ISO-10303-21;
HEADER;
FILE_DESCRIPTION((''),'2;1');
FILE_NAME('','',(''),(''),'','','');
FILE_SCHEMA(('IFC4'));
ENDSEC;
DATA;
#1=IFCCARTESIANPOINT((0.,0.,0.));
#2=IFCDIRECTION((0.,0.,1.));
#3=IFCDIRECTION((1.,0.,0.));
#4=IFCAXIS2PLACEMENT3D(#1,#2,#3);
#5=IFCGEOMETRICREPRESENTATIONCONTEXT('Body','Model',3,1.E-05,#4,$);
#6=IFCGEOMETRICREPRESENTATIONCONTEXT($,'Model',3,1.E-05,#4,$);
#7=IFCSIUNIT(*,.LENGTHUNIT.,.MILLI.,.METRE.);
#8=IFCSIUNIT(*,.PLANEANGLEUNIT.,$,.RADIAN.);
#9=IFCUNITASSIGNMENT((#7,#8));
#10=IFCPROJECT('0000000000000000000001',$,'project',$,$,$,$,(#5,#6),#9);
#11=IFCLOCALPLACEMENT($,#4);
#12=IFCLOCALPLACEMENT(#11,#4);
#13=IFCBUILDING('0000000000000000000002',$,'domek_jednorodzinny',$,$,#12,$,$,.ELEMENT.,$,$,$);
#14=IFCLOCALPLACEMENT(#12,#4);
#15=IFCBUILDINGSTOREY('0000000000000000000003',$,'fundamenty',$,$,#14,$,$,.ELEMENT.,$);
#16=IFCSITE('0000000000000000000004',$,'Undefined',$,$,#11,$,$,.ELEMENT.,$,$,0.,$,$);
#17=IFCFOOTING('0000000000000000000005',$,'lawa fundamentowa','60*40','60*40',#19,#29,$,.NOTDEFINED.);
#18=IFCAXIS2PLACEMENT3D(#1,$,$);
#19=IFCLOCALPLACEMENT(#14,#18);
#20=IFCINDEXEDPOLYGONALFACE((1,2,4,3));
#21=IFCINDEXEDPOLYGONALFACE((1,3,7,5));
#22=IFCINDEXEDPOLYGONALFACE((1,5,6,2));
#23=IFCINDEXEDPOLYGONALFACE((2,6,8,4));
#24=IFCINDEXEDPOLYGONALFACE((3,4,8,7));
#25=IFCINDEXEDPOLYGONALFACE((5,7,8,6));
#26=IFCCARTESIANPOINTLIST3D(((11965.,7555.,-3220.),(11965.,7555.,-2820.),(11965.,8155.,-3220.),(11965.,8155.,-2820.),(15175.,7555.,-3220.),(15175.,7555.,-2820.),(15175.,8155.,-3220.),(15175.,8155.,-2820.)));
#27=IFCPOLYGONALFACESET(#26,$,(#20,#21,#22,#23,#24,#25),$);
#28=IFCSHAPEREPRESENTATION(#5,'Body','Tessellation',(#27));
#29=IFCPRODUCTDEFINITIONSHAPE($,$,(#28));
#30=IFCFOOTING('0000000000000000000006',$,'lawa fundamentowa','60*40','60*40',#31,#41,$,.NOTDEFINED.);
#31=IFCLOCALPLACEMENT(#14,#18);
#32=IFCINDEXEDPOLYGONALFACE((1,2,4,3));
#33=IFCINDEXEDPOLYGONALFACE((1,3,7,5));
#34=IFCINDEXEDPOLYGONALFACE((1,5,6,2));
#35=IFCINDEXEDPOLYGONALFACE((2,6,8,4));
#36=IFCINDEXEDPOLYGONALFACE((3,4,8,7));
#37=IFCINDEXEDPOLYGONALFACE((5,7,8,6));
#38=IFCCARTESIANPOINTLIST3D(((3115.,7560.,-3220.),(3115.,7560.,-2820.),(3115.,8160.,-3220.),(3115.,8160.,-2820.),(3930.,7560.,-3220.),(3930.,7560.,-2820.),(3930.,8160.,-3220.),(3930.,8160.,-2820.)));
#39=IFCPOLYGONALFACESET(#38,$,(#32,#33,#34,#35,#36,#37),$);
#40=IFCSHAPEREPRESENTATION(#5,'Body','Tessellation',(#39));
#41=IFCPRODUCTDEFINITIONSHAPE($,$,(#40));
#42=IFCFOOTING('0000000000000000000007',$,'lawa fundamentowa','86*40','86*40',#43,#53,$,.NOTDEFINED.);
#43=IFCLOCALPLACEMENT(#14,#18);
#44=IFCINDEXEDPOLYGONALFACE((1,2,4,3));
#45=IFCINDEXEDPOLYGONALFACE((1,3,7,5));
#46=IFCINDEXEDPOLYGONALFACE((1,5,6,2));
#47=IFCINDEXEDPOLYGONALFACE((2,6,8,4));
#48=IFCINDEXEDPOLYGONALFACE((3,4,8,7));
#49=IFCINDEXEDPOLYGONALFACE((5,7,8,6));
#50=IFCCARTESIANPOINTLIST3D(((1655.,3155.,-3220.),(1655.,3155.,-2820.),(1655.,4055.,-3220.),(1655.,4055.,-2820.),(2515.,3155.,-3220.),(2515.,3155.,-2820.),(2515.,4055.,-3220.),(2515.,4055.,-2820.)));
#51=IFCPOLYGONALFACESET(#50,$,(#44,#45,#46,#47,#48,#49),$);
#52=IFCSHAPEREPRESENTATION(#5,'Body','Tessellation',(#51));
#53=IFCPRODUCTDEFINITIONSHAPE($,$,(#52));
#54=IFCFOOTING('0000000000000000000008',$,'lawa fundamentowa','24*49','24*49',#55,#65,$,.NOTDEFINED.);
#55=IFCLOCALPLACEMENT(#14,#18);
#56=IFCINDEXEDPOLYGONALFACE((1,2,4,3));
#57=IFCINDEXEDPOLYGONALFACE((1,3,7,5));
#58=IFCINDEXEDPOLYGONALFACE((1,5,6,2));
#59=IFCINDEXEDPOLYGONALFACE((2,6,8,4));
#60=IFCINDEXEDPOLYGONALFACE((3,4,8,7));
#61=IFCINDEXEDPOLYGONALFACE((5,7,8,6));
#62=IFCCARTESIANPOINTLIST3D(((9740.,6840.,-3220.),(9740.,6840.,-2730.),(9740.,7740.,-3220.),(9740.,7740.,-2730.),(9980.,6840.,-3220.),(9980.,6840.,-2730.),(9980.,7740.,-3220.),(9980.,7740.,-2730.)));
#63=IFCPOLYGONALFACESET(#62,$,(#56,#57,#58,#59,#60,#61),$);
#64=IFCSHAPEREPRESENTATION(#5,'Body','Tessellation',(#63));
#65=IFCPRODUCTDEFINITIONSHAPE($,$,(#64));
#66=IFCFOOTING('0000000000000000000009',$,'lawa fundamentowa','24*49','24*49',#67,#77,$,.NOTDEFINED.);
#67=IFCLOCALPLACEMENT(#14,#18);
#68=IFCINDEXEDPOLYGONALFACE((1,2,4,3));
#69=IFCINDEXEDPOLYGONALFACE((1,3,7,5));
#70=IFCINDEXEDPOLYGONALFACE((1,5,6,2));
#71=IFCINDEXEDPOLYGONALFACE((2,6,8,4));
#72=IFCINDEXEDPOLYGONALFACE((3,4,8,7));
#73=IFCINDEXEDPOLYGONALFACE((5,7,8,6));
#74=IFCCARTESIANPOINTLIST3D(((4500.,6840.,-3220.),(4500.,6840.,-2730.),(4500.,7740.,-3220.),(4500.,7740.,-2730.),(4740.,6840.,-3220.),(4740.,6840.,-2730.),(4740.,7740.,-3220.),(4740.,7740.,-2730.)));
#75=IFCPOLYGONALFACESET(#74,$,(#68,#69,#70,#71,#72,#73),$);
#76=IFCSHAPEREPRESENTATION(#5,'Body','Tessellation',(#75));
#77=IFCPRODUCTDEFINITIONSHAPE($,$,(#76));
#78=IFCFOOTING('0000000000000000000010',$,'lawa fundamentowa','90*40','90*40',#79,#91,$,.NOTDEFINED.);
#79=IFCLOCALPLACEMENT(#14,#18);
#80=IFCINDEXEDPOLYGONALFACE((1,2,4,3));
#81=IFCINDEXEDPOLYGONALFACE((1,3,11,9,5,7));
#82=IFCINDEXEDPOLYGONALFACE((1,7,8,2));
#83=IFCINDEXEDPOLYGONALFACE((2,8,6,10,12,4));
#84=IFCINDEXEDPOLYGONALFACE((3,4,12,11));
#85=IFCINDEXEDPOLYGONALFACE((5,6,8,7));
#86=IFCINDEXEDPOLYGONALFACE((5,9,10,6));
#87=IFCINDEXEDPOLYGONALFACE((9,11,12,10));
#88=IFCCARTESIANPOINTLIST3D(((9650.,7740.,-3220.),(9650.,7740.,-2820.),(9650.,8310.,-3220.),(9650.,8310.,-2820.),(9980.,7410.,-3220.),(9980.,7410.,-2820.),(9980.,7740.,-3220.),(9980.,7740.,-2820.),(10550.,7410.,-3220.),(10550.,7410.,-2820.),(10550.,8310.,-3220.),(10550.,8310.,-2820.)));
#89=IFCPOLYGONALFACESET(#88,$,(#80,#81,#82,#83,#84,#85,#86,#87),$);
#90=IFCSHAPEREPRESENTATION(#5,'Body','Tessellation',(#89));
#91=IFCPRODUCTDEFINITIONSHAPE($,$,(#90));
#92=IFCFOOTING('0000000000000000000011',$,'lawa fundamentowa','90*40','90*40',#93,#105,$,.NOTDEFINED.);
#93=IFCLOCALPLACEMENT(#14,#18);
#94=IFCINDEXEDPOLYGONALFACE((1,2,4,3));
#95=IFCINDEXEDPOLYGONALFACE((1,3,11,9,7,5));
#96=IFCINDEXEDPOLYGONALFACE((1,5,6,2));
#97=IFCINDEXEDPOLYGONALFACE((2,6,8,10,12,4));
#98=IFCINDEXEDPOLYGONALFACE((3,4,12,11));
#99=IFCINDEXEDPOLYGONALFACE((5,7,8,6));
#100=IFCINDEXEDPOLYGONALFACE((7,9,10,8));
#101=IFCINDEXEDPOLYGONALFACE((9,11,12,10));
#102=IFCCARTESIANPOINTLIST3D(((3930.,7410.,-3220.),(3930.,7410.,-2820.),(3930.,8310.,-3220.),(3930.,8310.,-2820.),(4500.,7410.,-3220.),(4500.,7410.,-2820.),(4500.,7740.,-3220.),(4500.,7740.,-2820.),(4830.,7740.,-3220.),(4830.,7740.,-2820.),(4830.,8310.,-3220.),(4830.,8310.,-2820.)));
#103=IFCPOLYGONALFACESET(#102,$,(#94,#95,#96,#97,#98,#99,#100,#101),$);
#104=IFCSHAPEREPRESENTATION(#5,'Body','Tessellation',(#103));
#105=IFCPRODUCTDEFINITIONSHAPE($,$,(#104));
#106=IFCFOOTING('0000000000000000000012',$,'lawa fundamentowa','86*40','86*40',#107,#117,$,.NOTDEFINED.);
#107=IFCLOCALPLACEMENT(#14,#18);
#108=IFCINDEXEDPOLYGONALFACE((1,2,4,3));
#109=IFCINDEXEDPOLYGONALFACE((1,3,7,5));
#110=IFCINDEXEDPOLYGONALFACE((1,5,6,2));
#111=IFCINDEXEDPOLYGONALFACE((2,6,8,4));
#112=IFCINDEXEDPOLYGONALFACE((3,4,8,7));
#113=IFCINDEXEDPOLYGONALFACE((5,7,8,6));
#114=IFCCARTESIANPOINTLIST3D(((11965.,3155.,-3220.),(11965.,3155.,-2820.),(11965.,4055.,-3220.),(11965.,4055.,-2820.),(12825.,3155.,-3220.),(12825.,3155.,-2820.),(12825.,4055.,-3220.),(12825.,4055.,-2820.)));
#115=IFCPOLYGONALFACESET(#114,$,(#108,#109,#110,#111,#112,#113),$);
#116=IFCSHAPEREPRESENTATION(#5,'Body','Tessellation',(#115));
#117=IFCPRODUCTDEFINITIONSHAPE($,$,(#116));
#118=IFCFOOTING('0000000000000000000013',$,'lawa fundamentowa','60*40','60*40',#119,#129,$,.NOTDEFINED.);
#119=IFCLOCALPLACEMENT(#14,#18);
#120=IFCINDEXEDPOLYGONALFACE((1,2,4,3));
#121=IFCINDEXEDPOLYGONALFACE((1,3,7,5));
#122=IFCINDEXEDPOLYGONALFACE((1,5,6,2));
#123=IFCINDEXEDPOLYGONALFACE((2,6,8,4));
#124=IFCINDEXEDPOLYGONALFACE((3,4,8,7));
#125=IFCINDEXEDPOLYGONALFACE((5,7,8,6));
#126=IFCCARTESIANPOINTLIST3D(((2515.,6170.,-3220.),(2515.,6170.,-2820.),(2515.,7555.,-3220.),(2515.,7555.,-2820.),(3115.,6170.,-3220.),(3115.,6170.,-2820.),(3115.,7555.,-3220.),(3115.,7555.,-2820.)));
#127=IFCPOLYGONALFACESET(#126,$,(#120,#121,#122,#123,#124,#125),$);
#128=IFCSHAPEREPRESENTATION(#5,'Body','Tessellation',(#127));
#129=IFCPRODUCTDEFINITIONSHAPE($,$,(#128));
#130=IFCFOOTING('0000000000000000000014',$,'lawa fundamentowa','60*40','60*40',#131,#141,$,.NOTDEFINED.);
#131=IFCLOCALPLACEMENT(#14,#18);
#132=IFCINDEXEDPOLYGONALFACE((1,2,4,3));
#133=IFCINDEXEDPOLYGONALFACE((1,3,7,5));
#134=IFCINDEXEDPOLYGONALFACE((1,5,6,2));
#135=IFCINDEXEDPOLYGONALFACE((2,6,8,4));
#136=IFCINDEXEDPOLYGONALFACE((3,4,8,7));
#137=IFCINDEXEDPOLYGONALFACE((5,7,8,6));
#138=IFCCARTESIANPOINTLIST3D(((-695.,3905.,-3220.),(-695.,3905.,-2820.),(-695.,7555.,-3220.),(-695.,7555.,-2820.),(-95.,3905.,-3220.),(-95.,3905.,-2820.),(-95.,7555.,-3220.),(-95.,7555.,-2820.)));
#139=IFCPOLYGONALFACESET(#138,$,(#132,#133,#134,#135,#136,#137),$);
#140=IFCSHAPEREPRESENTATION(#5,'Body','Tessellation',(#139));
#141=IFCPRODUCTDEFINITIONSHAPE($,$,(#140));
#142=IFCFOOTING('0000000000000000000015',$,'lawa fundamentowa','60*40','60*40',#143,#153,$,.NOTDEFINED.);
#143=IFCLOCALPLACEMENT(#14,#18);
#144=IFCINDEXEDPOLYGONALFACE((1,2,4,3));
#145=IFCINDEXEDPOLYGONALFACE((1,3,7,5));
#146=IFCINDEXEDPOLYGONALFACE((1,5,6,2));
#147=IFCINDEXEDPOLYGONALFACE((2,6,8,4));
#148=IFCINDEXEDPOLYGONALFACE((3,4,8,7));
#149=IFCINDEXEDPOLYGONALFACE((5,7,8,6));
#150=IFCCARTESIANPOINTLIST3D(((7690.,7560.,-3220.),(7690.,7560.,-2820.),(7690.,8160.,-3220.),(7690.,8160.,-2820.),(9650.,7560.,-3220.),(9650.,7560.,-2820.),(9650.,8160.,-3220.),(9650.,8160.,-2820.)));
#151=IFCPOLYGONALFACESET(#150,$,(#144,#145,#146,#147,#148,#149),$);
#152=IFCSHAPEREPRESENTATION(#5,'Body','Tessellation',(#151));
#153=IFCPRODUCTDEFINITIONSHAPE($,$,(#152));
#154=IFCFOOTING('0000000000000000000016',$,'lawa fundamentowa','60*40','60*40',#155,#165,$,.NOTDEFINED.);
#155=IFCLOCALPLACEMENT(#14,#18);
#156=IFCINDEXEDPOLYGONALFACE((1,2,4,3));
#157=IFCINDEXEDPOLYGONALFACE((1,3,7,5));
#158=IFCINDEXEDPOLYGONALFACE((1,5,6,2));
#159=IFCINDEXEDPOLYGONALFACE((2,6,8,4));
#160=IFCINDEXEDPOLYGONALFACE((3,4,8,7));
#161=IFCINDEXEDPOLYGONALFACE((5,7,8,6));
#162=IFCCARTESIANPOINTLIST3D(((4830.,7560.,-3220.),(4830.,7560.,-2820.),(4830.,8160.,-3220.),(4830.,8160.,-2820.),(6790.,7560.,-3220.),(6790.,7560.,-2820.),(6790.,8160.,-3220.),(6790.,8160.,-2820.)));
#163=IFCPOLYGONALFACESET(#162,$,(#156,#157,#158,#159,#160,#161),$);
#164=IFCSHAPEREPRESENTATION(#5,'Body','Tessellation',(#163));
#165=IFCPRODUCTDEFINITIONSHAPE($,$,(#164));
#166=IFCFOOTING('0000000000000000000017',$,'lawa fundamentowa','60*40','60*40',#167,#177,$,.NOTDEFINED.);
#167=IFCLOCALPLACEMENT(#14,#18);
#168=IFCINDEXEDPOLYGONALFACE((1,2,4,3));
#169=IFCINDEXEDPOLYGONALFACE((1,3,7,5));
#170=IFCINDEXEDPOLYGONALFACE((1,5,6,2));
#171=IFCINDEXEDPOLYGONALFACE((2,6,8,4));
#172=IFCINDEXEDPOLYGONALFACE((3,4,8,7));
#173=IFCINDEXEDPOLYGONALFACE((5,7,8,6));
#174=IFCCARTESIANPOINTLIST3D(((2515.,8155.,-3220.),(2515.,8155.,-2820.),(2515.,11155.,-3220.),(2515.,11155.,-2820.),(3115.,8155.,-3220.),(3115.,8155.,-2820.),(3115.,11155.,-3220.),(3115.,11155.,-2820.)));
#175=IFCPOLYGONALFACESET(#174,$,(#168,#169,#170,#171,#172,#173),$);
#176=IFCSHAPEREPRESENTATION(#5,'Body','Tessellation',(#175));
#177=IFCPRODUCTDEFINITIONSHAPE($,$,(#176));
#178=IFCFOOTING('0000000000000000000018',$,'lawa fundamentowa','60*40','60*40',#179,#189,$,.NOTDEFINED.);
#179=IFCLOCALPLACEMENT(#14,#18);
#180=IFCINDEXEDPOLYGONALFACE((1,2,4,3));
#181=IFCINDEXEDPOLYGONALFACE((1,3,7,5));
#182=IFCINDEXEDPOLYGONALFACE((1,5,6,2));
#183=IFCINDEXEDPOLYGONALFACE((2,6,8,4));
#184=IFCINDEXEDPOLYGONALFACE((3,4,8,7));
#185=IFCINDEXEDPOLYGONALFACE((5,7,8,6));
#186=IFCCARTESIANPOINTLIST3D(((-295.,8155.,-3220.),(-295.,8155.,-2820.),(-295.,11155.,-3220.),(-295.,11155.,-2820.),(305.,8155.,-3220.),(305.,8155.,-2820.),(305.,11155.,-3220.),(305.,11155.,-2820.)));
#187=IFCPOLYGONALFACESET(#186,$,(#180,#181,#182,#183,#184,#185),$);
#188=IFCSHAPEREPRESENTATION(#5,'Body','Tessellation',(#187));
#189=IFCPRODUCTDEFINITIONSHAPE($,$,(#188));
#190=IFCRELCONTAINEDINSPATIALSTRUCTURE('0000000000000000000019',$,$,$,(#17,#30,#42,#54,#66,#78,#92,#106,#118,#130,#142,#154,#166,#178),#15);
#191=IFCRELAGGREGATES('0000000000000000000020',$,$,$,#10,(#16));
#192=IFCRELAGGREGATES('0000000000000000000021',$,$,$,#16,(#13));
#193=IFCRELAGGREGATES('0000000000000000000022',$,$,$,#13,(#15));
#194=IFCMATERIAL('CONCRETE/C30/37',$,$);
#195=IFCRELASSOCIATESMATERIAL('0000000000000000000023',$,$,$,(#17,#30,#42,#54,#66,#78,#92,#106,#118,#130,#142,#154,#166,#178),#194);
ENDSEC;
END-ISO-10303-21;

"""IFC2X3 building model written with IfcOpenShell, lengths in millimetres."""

from ifc_helpers import new_model, si_unit, frame, origin_with_axes, origin_2d_with_axis, place, context, project, spatial, polyline, rectangle, outline, extrude, material, element, save


model = new_model("IFC2X3")

# Units and contexts
model_context_1 = context("Model", 3, precision=1e-05, world=origin_with_axes(), identifier="Body")
model_context_2 = context("Model", 3, precision=1e-05, world=origin_with_axes())
ifc_project = project(units=[si_unit("LENGTHUNIT", "METRE", prefix="MILLI"), si_unit("PLANEANGLEUNIT", "RADIAN")], contexts=[model_context_1, model_context_2])

# Site, building, storey
site_placement = place(None, origin_with_axes())
site = spatial("IfcSite", under=ifc_project, at=site_placement, Name="Undefined", CompositionType="ELEMENT", RefElevation=0.0)
building_placement = place(site_placement, origin_with_axes())
building = spatial("IfcBuilding", under=site, at=building_placement, Name="domek_jednorodzinny", CompositionType="ELEMENT")
storey_placement = place(building_placement, origin_with_axes())
storey = spatial("IfcBuildingStorey", under=building, at=storey_placement, Name="fundamenty", CompositionType="ELEMENT")

# Footings
ifc_material = material(Name="CONCRETE/C30/37")
footing_1_placement = place(storey_placement, frame((11965.0, 7855.0, -3020.0), z_axis=(0.0, 0.0, 1.0), x_axis=(1.0, 0.0, 0.0)))
element("IfcFooting", 1, at=footing_1_placement, inside=storey, material=ifc_material, Name="lawa fundamentowa", Description="60*40", ObjectType="60*40", PredefinedType="NOTDEFINED", context=model_context_1, shape_type="SweptSolid", body=[
    extrude(rectangle(XDim=600.0, YDim=400.0, at=origin_2d_with_axis()), frame((3210.0, 0.0, 0.0), z_axis=(-1.0, 0.0, 0.0), x_axis=(0.0, -1.0, 0.0)), (0.0, 0.0, 1.0), 3210.0),
])
footing_2_placement = place(storey_placement, frame((3115.0, 7860.0, -3020.0), z_axis=(0.0, 0.0, 1.0), x_axis=(1.0, 0.0, 0.0)))
element("IfcFooting", 2, at=footing_2_placement, inside=storey, material=ifc_material, Name="lawa fundamentowa", Description="60*40", ObjectType="60*40", PredefinedType="NOTDEFINED", context=model_context_1, shape_type="SweptSolid", body=[
    extrude(rectangle(XDim=600.0, YDim=400.0, at=origin_2d_with_axis()), frame((815.0, 0.0, 0.0), z_axis=(-1.0, 0.0, 0.0), x_axis=(0.0, -1.0, 0.0)), (0.0, 0.0, 1.0), 815.0),
])
footing_3_placement = place(storey_placement, frame((2085.0, 3155.0, -3020.0), z_axis=(0.0, 0.0, 1.0), x_axis=(0.0, 1.0, 0.0)))
element("IfcFooting", 3, at=footing_3_placement, inside=storey, material=ifc_material, Name="lawa fundamentowa", Description="86*40", ObjectType="86*40", PredefinedType="NOTDEFINED", context=model_context_1, shape_type="SweptSolid", body=[
    extrude(rectangle(XDim=860.0, YDim=400.0, at=origin_2d_with_axis()), frame((900.0, 0.0, 0.0), z_axis=(-1.0, 0.0, 0.0), x_axis=(0.0, -1.0, 0.0)), (0.0, 0.0, 1.0), 900.0),
])
footing_4_placement = place(storey_placement, frame((9860.0, 6840.0, -2975.0), z_axis=(0.0, 0.0, 1.0), x_axis=(0.0, 1.0, 0.0)))
element("IfcFooting", 4, at=footing_4_placement, inside=storey, material=ifc_material, Name="lawa fundamentowa", Description="24*49", ObjectType="24*49", PredefinedType="NOTDEFINED", context=model_context_1, shape_type="SweptSolid", body=[
    extrude(rectangle(XDim=240.0, YDim=490.0, at=origin_2d_with_axis()), frame((900.0, 0.0, 0.0), z_axis=(-1.0, 0.0, 0.0), x_axis=(0.0, -1.0, 0.0)), (0.0, 0.0, 1.0), 900.0),
])
footing_5_placement = place(storey_placement, frame((4620.0, 6840.0, -2975.0), z_axis=(0.0, 0.0, 1.0), x_axis=(0.0, 1.0, 0.0)))
element("IfcFooting", 5, at=footing_5_placement, inside=storey, material=ifc_material, Name="lawa fundamentowa", Description="24*49", ObjectType="24*49", PredefinedType="NOTDEFINED", context=model_context_1, shape_type="SweptSolid", body=[
    extrude(rectangle(XDim=240.0, YDim=490.0, at=origin_2d_with_axis()), frame((900.0, 0.0, 0.0), z_axis=(-1.0, 0.0, 0.0), x_axis=(0.0, -1.0, 0.0)), (0.0, 0.0, 1.0), 900.0),
])

# Footings, openings
footing_6_placement = place(storey_placement, frame((10100.0, 8310.0, -3020.0), z_axis=(0.0, 0.0, 1.0), x_axis=(0.0, -1.0, 0.0)))
footing_6 = element("IfcFooting", 6, at=footing_6_placement, inside=storey, material=ifc_material, Name="lawa fundamentowa", Description="90*40", ObjectType="90*40", PredefinedType="NOTDEFINED", context=model_context_1, shape_type="SweptSolid", body=[
    extrude(rectangle(XDim=900.0, YDim=400.0, at=origin_2d_with_axis()), frame((900.0, 0.0, 0.0), z_axis=(-1.0, 0.0, 0.0), x_axis=(0.0, -1.0, 0.0)), (0.0, 0.0, 1.0), 900.0),
])
opening_1_placement = place(storey_placement, frame((10100.0, 8310.0, -3020.0), z_axis=(0.0, 0.0, 1.0), x_axis=(0.0, -1.0, 0.0)))
element("IfcOpeningElement", 7, at=opening_1_placement, cuts=footing_6, ObjectType="Recess", context=model_context_1, shape_type="SweptSolid", body=[
    extrude(outline(polyline([(0.0, 0.0), (330.0, 0.0), (330.0, 330.0), (0.0, 330.0), (0.0, 0.0)])), frame((570.0, -450.0, 202.5), z_axis=(0.000001, 0.000001, -1.0), x_axis=(0.0, 1.0, 0.0)), (0.0, 0.0, 1.0), 405.0),
])
footing_7_placement = place(storey_placement, frame((3930.0, 7860.0, -3020.0), z_axis=(0.0, 0.0, 1.0), x_axis=(1.0, 0.0, 0.0)))
footing_7 = element("IfcFooting", 8, at=footing_7_placement, inside=storey, material=ifc_material, Name="lawa fundamentowa", Description="90*40", ObjectType="90*40", PredefinedType="NOTDEFINED", context=model_context_1, shape_type="SweptSolid", body=[
    extrude(rectangle(XDim=900.0, YDim=400.0, at=origin_2d_with_axis()), frame((900.0, 0.0, 0.0), z_axis=(-1.0, 0.0, 0.0), x_axis=(0.0, -1.0, 0.0)), (0.0, 0.0, 1.0), 900.0),
])
opening_2_placement = place(storey_placement, frame((3930.0, 7860.0, -3020.0), z_axis=(0.0, 0.0, 1.0), x_axis=(1.0, 0.0, 0.0)))
element("IfcOpeningElement", 9, at=opening_2_placement, cuts=footing_7, ObjectType="Recess", context=model_context_1, shape_type="SweptSolid", body=[
    extrude(outline(polyline([(0.0, 0.0), (330.0, 0.0), (330.0, 330.0), (0.0, 330.0), (0.0, 0.0)])), frame((900.0, -120.0, -202.5), z_axis=(0.0, 0.0, 1.0), x_axis=(-1.0, 0.0, 0.0)), (0.0, 0.0, 1.0), 405.0),
])

# Footings
footing_8_placement = place(storey_placement, frame((12395.0, 3155.0, -3020.0), z_axis=(0.0, 0.0, 1.0), x_axis=(0.0, 1.0, 0.0)))
element("IfcFooting", 10, at=footing_8_placement, inside=storey, material=ifc_material, Name="lawa fundamentowa", Description="86*40", ObjectType="86*40", PredefinedType="NOTDEFINED", context=model_context_1, shape_type="SweptSolid", body=[
    extrude(rectangle(XDim=860.0, YDim=400.0, at=origin_2d_with_axis()), frame((900.0, 0.0, 0.0), z_axis=(-1.0, 0.0, 0.0), x_axis=(0.0, -1.0, 0.0)), (0.0, 0.0, 1.0), 900.0),
])
footing_9_placement = place(storey_placement, frame((2815.0, 6170.0, -3020.0), z_axis=(0.0, 0.0, 1.0), x_axis=(0.0, 1.0, 0.0)))
element("IfcFooting", 11, at=footing_9_placement, inside=storey, material=ifc_material, Name="lawa fundamentowa", Description="60*40", ObjectType="60*40", PredefinedType="NOTDEFINED", context=model_context_1, shape_type="SweptSolid", body=[
    extrude(rectangle(XDim=600.0, YDim=400.0, at=origin_2d_with_axis()), frame((1385.0, 0.0, 0.0), z_axis=(-1.0, 0.0, 0.0), x_axis=(0.0, -1.0, 0.0)), (0.0, 0.0, 1.0), 1385.0),
])
footing_10_placement = place(storey_placement, frame((-395.0, 3905.0, -3020.0), z_axis=(0.0, 0.0, 1.0), x_axis=(0.0, 1.0, 0.0)))
element("IfcFooting", 12, at=footing_10_placement, inside=storey, material=ifc_material, Name="lawa fundamentowa", Description="60*40", ObjectType="60*40", PredefinedType="NOTDEFINED", context=model_context_1, shape_type="SweptSolid", body=[
    extrude(rectangle(XDim=600.0, YDim=400.0, at=origin_2d_with_axis()), frame((3650.0, 0.0, 0.0), z_axis=(-1.0, 0.0, 0.0), x_axis=(0.0, -1.0, 0.0)), (0.0, 0.0, 1.0), 3650.0),
])
footing_11_placement = place(storey_placement, frame((7690.0, 7860.0, -3020.0), z_axis=(0.0, 0.0, 1.0), x_axis=(1.0, 0.0, 0.0)))
element("IfcFooting", 13, at=footing_11_placement, inside=storey, material=ifc_material, Name="lawa fundamentowa", Description="60*40", ObjectType="60*40", PredefinedType="NOTDEFINED", context=model_context_1, shape_type="SweptSolid", body=[
    extrude(rectangle(XDim=600.0, YDim=400.0, at=origin_2d_with_axis()), frame((1960.0, 0.0, 0.0), z_axis=(-1.0, 0.0, 0.0), x_axis=(0.0, -1.0, 0.0)), (0.0, 0.0, 1.0), 1960.0),
])
footing_12_placement = place(storey_placement, frame((4830.0, 7860.0, -3020.0), z_axis=(0.0, 0.0, 1.0), x_axis=(1.0, 0.0, 0.0)))
element("IfcFooting", 14, at=footing_12_placement, inside=storey, material=ifc_material, Name="lawa fundamentowa", Description="60*40", ObjectType="60*40", PredefinedType="NOTDEFINED", context=model_context_1, shape_type="SweptSolid", body=[
    extrude(rectangle(XDim=600.0, YDim=400.0, at=origin_2d_with_axis()), frame((1960.0, 0.0, 0.0), z_axis=(-1.0, 0.0, 0.0), x_axis=(0.0, -1.0, 0.0)), (0.0, 0.0, 1.0), 1960.0),
])
for number, where, z_axis, x_axis, name in (
    (15, (2815.0, 8155.0, -3020.0), (0.0, 0.0, 1.0), (0.0, 1.0, 0.0), "lawa fundamentowa"),
    (16, (5.0, 8155.0, -3020.0), (0.0, 0.0, 1.0), (0.0, 1.0, 0.0), "lawa fundamentowa"),
):
    element("IfcFooting", number, at=place(storey_placement, frame(where, z_axis=z_axis, x_axis=x_axis)), inside=storey, material=ifc_material, Name=name, Description="60*40", ObjectType="60*40", PredefinedType="NOTDEFINED", context=model_context_1, shape_type="SweptSolid", body=[
        extrude(rectangle(XDim=600.0, YDim=400.0, at=origin_2d_with_axis()), frame((3000.0, 0.0, 0.0), z_axis=(-1.0, 0.0, 0.0), x_axis=(0.0, -1.0, 0.0)), (0.0, 0.0, 1.0), 3000.0),
    ])

save(model, "model.ifc")
